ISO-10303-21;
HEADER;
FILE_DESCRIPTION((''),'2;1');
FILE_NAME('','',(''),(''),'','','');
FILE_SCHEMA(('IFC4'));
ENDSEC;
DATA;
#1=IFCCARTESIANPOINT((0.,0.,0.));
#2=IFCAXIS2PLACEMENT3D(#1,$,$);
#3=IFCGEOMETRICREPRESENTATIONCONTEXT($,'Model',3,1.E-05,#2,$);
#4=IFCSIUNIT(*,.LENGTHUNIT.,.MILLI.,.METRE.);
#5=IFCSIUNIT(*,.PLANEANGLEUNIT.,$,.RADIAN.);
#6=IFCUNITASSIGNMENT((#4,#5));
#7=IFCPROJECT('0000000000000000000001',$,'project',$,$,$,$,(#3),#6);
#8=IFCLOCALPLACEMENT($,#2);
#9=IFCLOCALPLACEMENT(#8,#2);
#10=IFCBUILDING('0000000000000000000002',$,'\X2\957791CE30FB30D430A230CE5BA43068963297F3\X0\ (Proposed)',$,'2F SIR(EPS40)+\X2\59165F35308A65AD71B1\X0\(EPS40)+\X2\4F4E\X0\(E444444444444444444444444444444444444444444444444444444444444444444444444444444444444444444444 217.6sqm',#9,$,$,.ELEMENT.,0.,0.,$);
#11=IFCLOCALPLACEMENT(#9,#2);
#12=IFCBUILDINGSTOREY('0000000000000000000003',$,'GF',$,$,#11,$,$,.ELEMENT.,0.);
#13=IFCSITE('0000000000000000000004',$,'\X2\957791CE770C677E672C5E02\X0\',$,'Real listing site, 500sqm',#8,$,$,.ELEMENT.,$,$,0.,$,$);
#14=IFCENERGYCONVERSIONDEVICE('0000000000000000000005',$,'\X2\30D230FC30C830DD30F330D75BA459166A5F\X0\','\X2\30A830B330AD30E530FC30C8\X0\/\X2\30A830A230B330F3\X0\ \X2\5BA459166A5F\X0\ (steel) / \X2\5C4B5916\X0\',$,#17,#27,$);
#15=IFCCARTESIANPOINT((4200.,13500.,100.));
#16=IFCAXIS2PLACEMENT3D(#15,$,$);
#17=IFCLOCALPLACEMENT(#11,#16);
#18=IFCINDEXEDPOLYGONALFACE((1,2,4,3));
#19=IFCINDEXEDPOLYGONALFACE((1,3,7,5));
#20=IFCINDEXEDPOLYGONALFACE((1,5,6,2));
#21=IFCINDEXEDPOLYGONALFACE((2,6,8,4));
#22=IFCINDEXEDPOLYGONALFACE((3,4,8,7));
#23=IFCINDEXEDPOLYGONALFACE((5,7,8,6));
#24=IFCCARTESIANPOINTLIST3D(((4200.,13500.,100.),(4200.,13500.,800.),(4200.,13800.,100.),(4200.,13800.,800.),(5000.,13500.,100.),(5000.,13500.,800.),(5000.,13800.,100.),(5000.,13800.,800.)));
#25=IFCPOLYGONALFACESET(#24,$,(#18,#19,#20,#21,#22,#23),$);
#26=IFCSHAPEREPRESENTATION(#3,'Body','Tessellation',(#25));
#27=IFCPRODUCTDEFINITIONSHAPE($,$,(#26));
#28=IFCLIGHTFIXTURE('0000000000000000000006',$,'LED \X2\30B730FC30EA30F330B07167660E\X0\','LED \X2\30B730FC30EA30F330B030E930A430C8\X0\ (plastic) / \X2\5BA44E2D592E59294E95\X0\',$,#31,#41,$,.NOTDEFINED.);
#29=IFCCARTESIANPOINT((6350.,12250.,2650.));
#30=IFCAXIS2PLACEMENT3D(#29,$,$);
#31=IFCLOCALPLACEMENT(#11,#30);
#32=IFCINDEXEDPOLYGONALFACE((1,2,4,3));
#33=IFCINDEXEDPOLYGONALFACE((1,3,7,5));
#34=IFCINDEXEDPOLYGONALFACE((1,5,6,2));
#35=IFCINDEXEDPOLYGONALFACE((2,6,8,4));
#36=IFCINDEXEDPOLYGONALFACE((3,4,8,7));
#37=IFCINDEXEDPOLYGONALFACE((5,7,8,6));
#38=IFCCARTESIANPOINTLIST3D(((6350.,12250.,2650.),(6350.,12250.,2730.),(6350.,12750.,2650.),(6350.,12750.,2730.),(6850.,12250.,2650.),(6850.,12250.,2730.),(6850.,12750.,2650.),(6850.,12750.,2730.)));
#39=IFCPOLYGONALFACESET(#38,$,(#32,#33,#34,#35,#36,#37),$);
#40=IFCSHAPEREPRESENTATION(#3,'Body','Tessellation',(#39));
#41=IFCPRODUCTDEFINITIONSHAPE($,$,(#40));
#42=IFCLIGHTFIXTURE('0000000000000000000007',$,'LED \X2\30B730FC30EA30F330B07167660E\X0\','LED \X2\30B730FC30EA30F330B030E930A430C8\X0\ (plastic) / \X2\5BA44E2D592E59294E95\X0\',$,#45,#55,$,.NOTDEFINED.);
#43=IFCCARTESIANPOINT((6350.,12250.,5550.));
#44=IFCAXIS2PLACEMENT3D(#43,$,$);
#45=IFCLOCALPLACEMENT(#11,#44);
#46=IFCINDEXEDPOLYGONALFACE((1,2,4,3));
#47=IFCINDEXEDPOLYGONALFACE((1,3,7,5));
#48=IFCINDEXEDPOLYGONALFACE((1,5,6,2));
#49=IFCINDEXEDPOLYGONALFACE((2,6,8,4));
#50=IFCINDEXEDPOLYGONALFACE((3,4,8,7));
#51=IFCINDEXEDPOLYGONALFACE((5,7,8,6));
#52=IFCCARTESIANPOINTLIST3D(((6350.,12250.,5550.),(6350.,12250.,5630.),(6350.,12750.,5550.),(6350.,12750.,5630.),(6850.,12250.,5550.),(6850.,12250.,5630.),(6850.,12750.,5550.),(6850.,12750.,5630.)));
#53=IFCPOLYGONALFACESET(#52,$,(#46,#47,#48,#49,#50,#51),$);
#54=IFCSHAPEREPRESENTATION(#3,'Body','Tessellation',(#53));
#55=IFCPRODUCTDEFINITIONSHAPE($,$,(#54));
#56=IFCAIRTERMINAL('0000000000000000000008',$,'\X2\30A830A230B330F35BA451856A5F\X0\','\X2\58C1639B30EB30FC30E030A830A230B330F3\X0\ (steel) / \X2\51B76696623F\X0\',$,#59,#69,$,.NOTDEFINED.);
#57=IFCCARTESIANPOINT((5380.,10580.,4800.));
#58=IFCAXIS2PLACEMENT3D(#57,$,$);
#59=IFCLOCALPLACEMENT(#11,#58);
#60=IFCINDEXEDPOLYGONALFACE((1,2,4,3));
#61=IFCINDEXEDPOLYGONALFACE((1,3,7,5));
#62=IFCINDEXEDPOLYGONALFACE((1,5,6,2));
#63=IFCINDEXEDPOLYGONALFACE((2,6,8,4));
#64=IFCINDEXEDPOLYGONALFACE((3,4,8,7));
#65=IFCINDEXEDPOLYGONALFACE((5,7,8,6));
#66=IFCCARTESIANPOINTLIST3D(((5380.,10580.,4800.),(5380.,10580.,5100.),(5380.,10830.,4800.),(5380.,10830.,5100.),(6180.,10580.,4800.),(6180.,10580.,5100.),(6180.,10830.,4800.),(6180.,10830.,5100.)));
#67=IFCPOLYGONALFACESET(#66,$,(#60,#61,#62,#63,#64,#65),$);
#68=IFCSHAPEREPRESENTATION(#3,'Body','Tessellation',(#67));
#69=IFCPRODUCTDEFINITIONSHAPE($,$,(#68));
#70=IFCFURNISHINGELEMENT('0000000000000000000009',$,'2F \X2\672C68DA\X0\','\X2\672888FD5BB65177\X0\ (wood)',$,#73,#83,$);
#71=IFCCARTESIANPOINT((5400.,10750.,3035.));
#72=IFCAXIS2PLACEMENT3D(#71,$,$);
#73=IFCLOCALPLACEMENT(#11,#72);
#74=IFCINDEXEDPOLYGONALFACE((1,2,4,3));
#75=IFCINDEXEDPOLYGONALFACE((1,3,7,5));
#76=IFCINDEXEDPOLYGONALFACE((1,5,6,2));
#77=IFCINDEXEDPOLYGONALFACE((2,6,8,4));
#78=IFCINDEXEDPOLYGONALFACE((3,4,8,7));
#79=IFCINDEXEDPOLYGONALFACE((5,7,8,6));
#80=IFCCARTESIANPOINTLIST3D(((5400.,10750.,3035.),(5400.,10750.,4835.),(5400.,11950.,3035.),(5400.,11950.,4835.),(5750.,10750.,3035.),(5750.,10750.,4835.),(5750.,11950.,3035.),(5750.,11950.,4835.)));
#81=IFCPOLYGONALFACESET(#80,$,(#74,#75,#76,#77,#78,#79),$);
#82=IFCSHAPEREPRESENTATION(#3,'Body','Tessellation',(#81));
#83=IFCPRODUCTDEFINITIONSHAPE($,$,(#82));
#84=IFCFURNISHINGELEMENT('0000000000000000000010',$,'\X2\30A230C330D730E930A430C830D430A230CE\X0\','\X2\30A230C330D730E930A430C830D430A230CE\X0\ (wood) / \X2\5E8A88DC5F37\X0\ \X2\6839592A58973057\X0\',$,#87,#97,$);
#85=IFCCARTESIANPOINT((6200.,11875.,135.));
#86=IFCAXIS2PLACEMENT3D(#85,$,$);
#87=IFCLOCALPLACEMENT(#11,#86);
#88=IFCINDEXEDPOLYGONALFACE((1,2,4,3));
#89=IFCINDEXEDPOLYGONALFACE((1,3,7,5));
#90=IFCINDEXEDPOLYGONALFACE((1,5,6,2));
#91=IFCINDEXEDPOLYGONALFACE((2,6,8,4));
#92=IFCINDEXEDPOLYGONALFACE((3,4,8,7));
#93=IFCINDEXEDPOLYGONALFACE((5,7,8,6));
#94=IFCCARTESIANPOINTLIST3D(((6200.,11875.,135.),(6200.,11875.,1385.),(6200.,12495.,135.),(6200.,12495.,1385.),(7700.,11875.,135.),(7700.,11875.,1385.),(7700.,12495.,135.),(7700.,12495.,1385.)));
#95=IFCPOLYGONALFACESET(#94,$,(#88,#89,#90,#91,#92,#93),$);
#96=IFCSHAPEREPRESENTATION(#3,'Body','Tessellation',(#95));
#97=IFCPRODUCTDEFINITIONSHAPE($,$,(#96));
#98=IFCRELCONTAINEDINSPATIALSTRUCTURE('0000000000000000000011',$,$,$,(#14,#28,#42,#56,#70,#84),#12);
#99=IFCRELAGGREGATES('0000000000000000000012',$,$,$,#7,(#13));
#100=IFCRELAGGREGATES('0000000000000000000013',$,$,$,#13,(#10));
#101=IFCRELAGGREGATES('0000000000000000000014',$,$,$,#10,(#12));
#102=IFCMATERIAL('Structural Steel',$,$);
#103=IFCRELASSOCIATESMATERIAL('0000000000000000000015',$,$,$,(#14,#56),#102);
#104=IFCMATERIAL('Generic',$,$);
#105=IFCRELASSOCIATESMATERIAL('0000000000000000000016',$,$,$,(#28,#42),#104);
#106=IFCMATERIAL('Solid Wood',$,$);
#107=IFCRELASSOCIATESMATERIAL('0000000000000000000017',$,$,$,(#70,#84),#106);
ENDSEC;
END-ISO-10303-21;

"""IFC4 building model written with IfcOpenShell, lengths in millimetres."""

from ifc_helpers import new_model, si_unit, frame, frame_2d, origin, place, context, project, spatial, rectangle, extrude, material, element, save


model = new_model("IFC4")

# Units and contexts
model_context = context("Model", 3, precision=1e-05, world=origin())
ifc_project = project(units=[si_unit("LENGTHUNIT", "METRE", prefix="MILLI"), si_unit("PLANEANGLEUNIT", "RADIAN")], contexts=[model_context])

# Site, building, storey
site_placement = place(None, origin())
site = spatial("IfcSite", under=ifc_project, at=site_placement, Name="長野県松本市", ObjectType="Real listing site, 500sqm", CompositionType="ELEMENT", RefElevation=0.0)
building_placement = place(site_placement, origin())
building = spatial("IfcBuilding", under=site, at=building_placement, Name="長野・ピアノ室と防音 (Proposed)", ObjectType="2F SIR(EPS40)+外張り断熱(EPS40)+低(E444444444444444444444444444444444444444444444444444444444444444444444444444444444444444444444 217.6sqm", CompositionType="ELEMENT", ElevationOfRefHeight=0.0, ElevationOfTerrain=0.0)
storey_placement = place(building_placement, origin())
storey = spatial("IfcBuildingStorey", under=building, at=storey_placement, Name="GF", CompositionType="ELEMENT", Elevation=0.0)

# Shared definitions
ifc_material_1 = material(Name="Solid Wood")

# Shared definitions
ifc_material_2 = material(Name="Structural Steel")

# Shared definitions
ifc_material_3 = material(Name="Generic")

# Energy conversion device
energy_conversion_device_placement = place(storey_placement, frame((4200.0, 13500.0, 100.0)))
element("IfcEnergyConversionDevice", 1, at=energy_conversion_device_placement, inside=storey, material=ifc_material_2, Name="ヒートポンプ室外機", Description="エコキュート/エアコン 室外機 (steel) / 屋外", context=model_context, shape_type="SweptSolid", body=[
    extrude(rectangle(XDim=800.0, YDim=300.0, at=frame_2d((400.0, 150.0))), frame((4200.0, 13500.0, 100.0)), (0.0, 0.0, 1.0), 700.0),
])

# Light fixtures
light_fixture_1_placement = place(storey_placement, frame((6350.0, 12250.0, 2650.0)))
element("IfcLightFixture", 2, at=light_fixture_1_placement, inside=storey, material=ifc_material_3, Name="LED シーリング照明", Description="LED シーリングライト (plastic) / 室中央天井", PredefinedType="NOTDEFINED", context=model_context, shape_type="SweptSolid", body=[
    extrude(rectangle(XDim=500.0, YDim=500.0, at=frame_2d((250.0, 250.0))), frame((6350.0, 12250.0, 2650.0)), (0.0, 0.0, 1.0), 80.0),
])
light_fixture_2_placement = place(storey_placement, frame((6350.0, 12250.0, 5550.0)))
element("IfcLightFixture", 3, at=light_fixture_2_placement, inside=storey, material=ifc_material_3, Name="LED シーリング照明", Description="LED シーリングライト (plastic) / 室中央天井", PredefinedType="NOTDEFINED", context=model_context, shape_type="SweptSolid", body=[
    extrude(rectangle(XDim=500.0, YDim=500.0, at=frame_2d((250.0, 250.0))), frame((6350.0, 12250.0, 5550.0)), (0.0, 0.0, 1.0), 80.0),
])

# Air terminal
air_terminal_placement = place(storey_placement, frame((5380.0, 10580.0, 4800.0)))
element("IfcAirTerminal", 4, at=air_terminal_placement, inside=storey, material=ifc_material_2, Name="エアコン室内機", Description="壁掛ルームエアコン (steel) / 冷暖房", PredefinedType="NOTDEFINED", context=model_context, shape_type="SweptSolid", body=[
    extrude(rectangle(XDim=800.0, YDim=250.0, at=frame_2d((400.0, 125.0))), frame((5380.0, 10580.0, 4800.0)), (0.0, 0.0, 1.0), 300.0),
])

# Furnishing elements
furnishing_1_placement = place(storey_placement, frame((5400.0, 10750.0, 3035.0)))
element("IfcFurnishingElement", 5, at=furnishing_1_placement, inside=storey, material=ifc_material_1, Name="2F 本棚", Description="木製家具 (wood)", context=model_context, shape_type="SweptSolid", body=[
    extrude(rectangle(XDim=350.0, YDim=1200.0, at=frame_2d((175.0, 600.0))), frame((5400.0, 10750.0, 3035.0)), (0.0, 0.0, 1.0), 1800.0),
])
furnishing_2_placement = place(storey_placement, frame((6200.0, 11875.0, 135.0)))
element("IfcFurnishingElement", 6, at=furnishing_2_placement, inside=storey, material=ifc_material_1, Name="アップライトピアノ", Description="アップライトピアノ (wood) / 床補強 根太増し", context=model_context, shape_type="SweptSolid", body=[
    extrude(rectangle(XDim=1500.0, YDim=620.0, at=frame_2d((750.0, 310.0))), frame((6200.0, 11875.0, 135.0)), (0.0, 0.0, 1.0), 1250.0),
])

save(model, "model.ifc")
